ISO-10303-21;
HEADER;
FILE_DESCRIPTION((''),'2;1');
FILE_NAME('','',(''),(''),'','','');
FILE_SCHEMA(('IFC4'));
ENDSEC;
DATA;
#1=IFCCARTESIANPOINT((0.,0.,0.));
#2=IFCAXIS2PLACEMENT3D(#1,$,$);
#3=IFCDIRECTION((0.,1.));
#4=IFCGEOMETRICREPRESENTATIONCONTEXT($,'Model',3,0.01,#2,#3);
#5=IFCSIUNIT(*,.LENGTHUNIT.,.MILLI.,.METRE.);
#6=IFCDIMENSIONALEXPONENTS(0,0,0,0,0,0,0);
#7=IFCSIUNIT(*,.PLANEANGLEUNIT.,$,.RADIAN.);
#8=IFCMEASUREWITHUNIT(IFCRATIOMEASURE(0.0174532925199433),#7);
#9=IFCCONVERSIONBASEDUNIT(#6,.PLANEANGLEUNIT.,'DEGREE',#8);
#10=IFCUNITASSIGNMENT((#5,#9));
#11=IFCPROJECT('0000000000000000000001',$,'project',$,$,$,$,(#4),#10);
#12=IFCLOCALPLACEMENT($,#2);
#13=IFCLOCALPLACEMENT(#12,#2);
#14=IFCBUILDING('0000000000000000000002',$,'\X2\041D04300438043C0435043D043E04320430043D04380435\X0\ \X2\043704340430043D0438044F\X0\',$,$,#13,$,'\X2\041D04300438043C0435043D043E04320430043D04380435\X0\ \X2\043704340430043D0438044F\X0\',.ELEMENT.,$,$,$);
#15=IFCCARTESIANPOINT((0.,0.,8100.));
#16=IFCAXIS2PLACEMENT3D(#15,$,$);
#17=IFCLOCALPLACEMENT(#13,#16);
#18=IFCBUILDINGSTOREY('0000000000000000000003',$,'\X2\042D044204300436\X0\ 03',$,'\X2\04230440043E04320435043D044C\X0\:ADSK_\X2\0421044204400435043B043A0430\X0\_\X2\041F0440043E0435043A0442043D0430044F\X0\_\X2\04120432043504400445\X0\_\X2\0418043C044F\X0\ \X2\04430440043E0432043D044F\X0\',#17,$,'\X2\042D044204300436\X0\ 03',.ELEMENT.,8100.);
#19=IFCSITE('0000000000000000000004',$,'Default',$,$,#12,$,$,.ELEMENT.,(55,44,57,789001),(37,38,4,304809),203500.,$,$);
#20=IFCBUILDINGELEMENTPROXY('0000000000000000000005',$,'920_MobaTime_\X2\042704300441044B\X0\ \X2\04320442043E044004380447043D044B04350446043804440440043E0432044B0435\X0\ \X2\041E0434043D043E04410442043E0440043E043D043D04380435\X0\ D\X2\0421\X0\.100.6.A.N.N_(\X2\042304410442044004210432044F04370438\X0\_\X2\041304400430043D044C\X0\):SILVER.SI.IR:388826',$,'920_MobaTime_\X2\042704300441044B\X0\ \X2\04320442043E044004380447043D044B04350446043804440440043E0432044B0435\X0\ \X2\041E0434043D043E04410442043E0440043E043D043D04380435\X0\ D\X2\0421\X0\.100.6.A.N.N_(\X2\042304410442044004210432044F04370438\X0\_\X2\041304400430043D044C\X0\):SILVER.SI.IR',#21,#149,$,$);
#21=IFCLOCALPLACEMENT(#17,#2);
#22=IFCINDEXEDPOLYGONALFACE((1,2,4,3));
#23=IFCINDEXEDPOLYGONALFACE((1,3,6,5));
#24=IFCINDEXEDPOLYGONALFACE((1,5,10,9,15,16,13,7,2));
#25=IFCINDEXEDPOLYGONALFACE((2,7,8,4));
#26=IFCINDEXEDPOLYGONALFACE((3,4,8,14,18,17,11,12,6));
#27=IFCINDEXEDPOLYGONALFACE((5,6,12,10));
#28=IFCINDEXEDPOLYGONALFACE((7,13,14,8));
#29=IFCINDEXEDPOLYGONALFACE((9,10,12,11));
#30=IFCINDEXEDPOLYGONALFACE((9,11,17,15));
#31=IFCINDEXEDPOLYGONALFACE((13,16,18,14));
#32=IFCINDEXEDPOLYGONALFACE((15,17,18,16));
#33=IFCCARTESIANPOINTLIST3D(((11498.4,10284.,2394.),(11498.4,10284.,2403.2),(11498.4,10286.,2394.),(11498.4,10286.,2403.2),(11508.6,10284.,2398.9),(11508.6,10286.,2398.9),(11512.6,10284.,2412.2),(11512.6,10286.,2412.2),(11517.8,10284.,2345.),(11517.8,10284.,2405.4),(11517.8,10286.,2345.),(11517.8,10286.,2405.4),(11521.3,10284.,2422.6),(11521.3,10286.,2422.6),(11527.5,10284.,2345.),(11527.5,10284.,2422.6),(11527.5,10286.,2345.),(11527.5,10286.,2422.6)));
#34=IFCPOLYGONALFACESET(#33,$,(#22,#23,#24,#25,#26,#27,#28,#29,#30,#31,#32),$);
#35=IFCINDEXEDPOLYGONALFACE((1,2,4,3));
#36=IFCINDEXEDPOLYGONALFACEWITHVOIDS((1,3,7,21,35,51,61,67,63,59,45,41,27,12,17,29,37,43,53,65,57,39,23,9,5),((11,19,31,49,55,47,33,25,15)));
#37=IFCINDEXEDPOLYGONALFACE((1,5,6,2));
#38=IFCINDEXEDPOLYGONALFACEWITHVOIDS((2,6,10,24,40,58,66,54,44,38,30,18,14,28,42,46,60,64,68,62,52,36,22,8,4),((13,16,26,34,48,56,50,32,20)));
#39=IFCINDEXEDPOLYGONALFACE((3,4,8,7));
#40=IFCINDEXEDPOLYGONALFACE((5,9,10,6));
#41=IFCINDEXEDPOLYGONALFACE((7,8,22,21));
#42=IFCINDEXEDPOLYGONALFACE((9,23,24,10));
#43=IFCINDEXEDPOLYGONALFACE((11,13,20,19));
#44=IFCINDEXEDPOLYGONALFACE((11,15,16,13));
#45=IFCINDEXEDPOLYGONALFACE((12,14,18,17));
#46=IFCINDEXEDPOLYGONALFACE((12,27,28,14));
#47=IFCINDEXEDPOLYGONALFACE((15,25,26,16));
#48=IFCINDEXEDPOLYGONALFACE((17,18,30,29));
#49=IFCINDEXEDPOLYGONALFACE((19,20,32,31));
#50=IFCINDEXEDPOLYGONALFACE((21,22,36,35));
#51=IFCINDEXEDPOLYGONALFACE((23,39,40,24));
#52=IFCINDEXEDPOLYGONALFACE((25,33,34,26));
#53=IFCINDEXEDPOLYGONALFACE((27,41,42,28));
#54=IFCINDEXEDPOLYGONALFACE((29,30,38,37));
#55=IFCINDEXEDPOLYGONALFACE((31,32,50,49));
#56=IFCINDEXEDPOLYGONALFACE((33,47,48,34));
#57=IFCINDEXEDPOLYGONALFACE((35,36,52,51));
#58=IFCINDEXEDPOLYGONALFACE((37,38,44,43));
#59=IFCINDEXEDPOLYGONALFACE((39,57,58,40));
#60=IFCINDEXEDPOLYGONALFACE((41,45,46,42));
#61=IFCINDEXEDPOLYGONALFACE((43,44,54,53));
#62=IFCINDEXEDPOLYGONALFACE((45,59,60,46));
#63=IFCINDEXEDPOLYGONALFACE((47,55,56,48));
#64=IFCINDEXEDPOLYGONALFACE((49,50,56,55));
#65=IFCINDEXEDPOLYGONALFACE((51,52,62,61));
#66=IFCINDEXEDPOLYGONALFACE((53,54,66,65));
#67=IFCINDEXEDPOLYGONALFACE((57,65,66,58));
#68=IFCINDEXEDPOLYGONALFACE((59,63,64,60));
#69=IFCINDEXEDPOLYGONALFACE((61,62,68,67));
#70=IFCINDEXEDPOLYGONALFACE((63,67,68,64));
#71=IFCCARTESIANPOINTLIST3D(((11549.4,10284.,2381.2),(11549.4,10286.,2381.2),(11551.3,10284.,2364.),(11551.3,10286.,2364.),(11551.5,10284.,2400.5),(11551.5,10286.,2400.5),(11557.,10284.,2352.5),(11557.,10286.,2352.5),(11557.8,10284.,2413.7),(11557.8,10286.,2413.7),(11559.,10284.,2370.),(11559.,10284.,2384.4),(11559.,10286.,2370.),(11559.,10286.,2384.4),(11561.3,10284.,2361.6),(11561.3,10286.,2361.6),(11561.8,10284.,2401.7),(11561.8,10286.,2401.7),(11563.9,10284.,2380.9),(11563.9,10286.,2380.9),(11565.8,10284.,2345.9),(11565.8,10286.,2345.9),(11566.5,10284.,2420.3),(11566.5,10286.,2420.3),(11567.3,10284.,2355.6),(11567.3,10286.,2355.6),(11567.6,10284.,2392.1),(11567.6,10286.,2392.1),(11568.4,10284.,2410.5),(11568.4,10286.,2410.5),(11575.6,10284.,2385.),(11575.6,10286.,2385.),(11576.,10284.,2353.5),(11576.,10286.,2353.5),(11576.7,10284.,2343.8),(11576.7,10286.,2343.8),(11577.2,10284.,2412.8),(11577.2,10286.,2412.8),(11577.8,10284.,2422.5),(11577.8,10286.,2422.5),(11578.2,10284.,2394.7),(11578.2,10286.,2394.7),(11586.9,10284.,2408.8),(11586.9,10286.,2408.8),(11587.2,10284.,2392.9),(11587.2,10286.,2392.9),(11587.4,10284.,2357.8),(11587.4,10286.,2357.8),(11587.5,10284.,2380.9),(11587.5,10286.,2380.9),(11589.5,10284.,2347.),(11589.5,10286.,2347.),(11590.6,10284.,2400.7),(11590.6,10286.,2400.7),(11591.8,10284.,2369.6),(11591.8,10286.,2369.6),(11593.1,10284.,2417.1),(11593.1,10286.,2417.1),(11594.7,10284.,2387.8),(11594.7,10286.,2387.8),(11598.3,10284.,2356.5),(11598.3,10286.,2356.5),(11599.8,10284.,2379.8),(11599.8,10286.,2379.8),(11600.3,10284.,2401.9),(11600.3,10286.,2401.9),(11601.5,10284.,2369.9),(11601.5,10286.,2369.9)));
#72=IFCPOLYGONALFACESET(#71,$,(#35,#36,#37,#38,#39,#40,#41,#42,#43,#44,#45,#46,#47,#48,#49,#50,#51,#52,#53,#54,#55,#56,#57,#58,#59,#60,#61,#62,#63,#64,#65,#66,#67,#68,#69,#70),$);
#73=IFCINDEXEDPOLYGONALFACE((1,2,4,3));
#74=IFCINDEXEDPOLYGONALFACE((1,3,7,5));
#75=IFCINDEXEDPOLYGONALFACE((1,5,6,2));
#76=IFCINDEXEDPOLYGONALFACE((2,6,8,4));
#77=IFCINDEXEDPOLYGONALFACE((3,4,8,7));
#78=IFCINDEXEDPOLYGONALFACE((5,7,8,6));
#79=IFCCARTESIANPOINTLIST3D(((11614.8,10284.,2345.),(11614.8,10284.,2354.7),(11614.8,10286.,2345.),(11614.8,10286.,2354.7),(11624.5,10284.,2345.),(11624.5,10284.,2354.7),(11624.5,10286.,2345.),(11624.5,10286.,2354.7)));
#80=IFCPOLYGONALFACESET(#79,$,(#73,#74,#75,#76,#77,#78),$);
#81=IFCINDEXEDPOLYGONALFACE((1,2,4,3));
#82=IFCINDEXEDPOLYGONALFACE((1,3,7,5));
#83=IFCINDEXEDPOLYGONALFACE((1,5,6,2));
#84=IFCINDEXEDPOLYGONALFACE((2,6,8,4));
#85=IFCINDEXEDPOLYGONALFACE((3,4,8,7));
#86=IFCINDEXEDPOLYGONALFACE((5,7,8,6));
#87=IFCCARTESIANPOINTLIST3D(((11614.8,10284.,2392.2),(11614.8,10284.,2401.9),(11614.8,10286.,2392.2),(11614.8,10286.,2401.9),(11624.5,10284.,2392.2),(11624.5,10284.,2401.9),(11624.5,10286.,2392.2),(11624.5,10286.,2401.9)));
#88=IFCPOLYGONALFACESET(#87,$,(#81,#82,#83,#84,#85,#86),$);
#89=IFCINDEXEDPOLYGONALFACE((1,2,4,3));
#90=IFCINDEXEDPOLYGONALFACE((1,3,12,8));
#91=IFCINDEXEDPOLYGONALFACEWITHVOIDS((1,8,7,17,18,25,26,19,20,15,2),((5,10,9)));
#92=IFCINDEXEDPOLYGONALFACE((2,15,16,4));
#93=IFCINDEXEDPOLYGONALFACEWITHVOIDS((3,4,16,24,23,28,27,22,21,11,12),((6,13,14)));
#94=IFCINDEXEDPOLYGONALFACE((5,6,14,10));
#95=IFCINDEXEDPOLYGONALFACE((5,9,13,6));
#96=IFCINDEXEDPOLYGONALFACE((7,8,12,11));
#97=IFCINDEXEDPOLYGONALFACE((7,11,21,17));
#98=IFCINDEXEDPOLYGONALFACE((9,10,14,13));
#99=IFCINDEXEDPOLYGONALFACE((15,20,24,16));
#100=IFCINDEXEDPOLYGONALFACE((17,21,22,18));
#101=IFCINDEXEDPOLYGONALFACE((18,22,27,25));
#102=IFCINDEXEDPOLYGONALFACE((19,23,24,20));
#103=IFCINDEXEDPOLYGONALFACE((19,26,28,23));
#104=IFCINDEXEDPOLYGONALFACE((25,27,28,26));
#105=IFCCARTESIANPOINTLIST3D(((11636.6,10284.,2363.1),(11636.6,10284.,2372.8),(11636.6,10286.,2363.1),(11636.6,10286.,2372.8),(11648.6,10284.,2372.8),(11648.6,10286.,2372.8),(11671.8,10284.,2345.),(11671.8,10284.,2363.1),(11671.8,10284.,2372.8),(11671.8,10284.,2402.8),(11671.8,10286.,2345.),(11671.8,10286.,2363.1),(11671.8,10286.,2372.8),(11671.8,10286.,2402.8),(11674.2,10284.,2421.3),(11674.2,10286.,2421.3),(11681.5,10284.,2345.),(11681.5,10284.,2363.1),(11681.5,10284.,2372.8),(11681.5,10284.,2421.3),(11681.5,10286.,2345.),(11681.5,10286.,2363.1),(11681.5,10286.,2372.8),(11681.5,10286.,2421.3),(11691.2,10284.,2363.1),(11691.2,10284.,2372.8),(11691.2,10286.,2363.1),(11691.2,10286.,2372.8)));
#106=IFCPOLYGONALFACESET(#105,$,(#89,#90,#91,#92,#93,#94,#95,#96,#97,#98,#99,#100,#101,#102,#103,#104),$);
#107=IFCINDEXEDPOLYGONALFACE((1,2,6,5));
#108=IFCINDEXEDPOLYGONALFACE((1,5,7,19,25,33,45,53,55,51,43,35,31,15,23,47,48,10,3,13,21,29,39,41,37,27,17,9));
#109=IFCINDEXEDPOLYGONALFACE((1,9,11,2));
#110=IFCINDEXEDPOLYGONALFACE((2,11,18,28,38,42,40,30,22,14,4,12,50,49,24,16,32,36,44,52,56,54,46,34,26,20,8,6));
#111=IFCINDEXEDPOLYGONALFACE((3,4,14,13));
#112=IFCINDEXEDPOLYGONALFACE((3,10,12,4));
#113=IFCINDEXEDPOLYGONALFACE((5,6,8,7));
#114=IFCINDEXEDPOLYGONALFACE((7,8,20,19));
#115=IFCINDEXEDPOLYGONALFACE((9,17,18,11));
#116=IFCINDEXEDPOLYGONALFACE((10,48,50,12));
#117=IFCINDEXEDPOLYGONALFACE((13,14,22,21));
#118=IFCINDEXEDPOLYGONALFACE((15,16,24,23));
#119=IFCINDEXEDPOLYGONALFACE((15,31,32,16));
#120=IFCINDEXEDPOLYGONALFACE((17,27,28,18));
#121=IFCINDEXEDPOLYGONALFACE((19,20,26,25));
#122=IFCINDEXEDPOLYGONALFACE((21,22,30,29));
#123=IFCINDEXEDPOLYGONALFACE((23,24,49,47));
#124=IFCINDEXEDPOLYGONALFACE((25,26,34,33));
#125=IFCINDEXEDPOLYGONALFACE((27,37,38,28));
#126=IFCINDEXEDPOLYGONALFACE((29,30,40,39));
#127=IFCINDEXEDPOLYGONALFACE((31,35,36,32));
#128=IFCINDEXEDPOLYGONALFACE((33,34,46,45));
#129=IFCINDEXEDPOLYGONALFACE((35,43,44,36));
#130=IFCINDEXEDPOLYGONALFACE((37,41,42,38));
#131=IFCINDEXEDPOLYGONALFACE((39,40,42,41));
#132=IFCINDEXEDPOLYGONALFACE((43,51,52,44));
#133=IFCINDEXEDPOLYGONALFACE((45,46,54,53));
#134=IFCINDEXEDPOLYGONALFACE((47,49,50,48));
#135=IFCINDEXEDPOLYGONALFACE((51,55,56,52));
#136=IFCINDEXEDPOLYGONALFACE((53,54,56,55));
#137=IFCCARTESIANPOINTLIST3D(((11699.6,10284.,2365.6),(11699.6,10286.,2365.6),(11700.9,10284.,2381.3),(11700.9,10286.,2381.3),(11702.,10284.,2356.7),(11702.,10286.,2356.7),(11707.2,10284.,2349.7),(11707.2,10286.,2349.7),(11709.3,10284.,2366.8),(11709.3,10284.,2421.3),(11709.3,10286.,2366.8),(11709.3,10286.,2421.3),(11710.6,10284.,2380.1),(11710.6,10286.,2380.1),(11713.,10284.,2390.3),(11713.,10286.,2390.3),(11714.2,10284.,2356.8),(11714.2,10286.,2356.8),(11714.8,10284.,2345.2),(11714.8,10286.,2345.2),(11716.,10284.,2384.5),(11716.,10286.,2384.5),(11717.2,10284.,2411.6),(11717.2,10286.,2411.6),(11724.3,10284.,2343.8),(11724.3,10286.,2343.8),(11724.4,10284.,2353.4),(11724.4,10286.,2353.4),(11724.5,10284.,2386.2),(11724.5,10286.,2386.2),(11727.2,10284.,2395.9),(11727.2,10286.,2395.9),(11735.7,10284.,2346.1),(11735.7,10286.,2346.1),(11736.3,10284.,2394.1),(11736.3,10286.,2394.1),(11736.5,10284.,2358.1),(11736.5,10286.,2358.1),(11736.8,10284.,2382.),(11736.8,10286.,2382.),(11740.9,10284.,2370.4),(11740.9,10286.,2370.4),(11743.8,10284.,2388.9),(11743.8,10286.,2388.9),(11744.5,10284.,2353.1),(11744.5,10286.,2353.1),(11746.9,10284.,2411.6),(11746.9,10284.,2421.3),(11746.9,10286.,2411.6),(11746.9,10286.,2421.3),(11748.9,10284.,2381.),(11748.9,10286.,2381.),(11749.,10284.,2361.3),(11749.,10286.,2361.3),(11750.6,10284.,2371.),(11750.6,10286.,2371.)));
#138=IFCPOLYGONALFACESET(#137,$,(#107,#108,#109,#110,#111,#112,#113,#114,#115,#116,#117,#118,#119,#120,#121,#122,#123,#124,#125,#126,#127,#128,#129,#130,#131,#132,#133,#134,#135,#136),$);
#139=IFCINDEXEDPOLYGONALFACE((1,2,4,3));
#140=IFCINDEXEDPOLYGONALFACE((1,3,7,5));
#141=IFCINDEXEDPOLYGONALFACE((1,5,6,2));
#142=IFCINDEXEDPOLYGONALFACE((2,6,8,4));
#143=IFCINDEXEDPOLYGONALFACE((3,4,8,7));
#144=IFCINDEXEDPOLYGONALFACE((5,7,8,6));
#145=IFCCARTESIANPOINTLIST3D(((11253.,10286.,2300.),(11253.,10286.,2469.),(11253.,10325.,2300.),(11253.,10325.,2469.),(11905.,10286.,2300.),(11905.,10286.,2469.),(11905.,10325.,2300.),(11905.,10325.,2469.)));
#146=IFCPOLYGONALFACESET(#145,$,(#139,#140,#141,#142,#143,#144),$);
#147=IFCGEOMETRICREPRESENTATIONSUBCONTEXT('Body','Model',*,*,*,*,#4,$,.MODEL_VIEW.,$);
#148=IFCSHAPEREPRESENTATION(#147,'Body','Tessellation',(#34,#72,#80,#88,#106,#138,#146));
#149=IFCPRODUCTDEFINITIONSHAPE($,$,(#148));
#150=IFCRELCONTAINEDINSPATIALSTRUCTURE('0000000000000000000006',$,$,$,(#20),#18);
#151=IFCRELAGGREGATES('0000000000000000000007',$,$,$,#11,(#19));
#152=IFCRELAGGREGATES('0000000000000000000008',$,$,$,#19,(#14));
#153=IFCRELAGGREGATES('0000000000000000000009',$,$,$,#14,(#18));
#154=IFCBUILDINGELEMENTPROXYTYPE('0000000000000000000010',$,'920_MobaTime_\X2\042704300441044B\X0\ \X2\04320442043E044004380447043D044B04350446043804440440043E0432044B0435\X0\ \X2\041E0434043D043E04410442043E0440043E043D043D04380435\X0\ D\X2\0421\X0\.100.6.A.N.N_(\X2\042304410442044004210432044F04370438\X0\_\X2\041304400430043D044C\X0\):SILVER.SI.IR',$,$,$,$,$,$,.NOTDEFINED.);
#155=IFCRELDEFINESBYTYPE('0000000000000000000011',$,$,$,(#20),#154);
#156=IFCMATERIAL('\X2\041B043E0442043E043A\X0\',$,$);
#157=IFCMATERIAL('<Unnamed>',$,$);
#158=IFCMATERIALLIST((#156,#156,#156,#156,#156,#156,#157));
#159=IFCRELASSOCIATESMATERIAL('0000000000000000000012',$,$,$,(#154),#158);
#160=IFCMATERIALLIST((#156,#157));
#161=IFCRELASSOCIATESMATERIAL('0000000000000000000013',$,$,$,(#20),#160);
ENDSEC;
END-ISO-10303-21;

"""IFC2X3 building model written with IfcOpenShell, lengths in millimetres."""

from ifc_helpers import new_model, entity, si_unit, converted_unit, direction, frame, origin, origin_2d_with_axis, place, context, subcontext, project, spatial, polyline, rectangle, outline, extrude, source, transform, mapped, material, material_list, type_object, type_shapes, element, save


model = new_model("IFC2X3")

# Units and contexts
model_context = context("Model", 3, precision=0.01, world=origin(), true_north=direction((0.0, 1.0)))
body_context = subcontext(model_context, "Body", "Model", "MODEL_VIEW")
ifc_project = project(units=[si_unit("LENGTHUNIT", "METRE", prefix="MILLI"), converted_unit("PLANEANGLEUNIT", "DEGREE", entity("IfcRatioMeasure", 0.0174532925199433), si_unit("PLANEANGLEUNIT", "RADIAN"), dimensions=[0, 0, 0, 0, 0, 0, 0])], contexts=[model_context])

# Site, building, storey
site_placement = place(None, origin())
site = spatial("IfcSite", under=ifc_project, at=site_placement, Name="Default", CompositionType="ELEMENT", RefLatitude=(55, 44, 57, 789001), RefLongitude=(37, 38, 4, 304809), RefElevation=203500.0)
building_placement = place(site_placement, origin())
building = spatial("IfcBuilding", under=site, at=building_placement, Name="Наименование здания", LongName="Наименование здания", CompositionType="ELEMENT")
storey_placement = place(building_placement, frame((0.0, 0.0, 8100.0)))
storey = spatial("IfcBuildingStorey", under=building, at=storey_placement, Name="Этаж 03", ObjectType="Уровень:ADSK_Стрелка_Проектная_Вверх_Имя уровня", LongName="Этаж 03", CompositionType="ELEMENT", Elevation=8100.0)

# Building element proxy
ifc_material_1 = material(Name="Лоток")
ifc_material_2 = material(Name="<Unnamed>")
ifc_material_list_1 = material_list([ifc_material_1, ifc_material_1, ifc_material_1, ifc_material_1, ifc_material_1, ifc_material_1, ifc_material_2])
building_element_proxy_type = type_object("IfcBuildingElementProxyType", Name="920_MobaTime_Часы вторичныецифровые Односторонние DС.100.6.A.N.N_(УстрСвязи_Грань):SILVER.SI.IR", PredefinedType="NOTDEFINED", material=ifc_material_list_1)
shared_shape = source(origin(), body_context, "Body", "SweptSolid", [
    extrude(outline(polyline([(-49.3, -13.1), (28.2, -13.1), (28.2, -6.8), (17.9, 1.8), (8.8, 16.0), (-0.3, 16.0), (4.6, 5.8), (11.1, -3.4), (-49.3, -3.4), (-49.3, -13.1)])), frame((-64.6, 9.8, 39.0), z_axis=(0.0, 0.0, 1.0), x_axis=(0.0, 1.0, 0.0)), (0.0, 0.0, 1.0), 2.0),
    extrude(outline(polyline([(2.2, -27.6), (19.0, -27.6), (30.5, -16.1), (33.3, -4.9), (31.0, 5.8), (21.8, 17.2), (5.2, 27.3), (-11.1, 33.0), (-24.0, 32.7), (-33.6, 27.6), (-40.3, 18.6), (-42.8, 5.7), (-38.0, -6.3), (-27.2, -14.9), (-17.5, -17.7), (-8.2, -16.4), (-0.3, -11.9), (5.1, -4.5), (7.3, 6.2), (4.0, 17.2), (18.4, 7.3), (23.6, -2.4), (22.0, -11.4), (14.2, -18.4), (5.3, -18.3), (2.2, -27.6)]), holes=[polyline([(-9.0, 23.3), (-1.3, 14.3), (-2.5, 2.0), (-11.4, -7.0), (-23.4, -6.0), (-32.2, 2.9), (-31.2, 15.1), (-25.6, 22.1), (-17.5, 24.9), (-9.0, 23.3)])]), frame((-2.7, 3.6, 39.0), z_axis=(0.0, 0.0, 1.0), x_axis=(-0.427649, 0.903945, 0.0)), (0.0, 0.0, 1.0), 2.0),
    extrude(rectangle(XDim=9.7, YDim=9.7, at=origin_2d_with_axis()), frame((40.6, -34.7, 39.0)), (0.0, 0.0, 1.0), 2.0),
    extrude(rectangle(XDim=9.7, YDim=9.7, at=origin_2d_with_axis()), frame((40.6, 12.6, 39.0)), (0.0, 0.0, 1.0), 2.0),
    extrude(outline(polyline([(-0.9, -28.1), (8.8, -28.1), (8.8, -9.9), (18.5, -9.9), (18.5, -0.2), (8.8, -0.2), (8.8, 48.3), (1.5, 48.3), (-36.0, -0.2), (-36.0, -9.9), (-0.9, -9.9), (-0.9, -28.1)]), holes=[polyline([(-0.9, -0.2), (-24.1, -0.2), (-0.9, 29.7), (-0.9, -0.2)])]), frame((93.6, -11.4, 39.0)), (0.0, 0.0, 1.0), 2.0),
    extrude(outline(polyline([(3.3, -28.3), (12.5, -28.3), (20.5, -25.0), (26.8, -18.9), (30.7, -10.0), (31.4, 1.6), (26.9, 11.8), (20.1, 18.4), (11.1, 22.3), (1.0, 23.3), (-7.9, 20.4), (-14.9, 14.5), (-18.9, 6.2), (-17.1, -9.0), (-36.7, 0.5), (-29.1, 29.2), (-38.5, 31.7), (-48.1, -4.6), (-11.6, -23.1), (-8.0, -14.0), (-10.8, -7.6), (-10.2, 1.1), (-3.0, 11.8), (9.2, 12.8), (20.0, 5.5), (21.4, -7.5), (15.5, -16.4), (4.6, -18.6), (3.3, -28.3)])), frame((147.1, -8.5, 39.0), z_axis=(0.0, 0.0, 1.0), x_axis=(0.256974, -0.966418, 0.0)), (0.0, 0.0, 1.0), 2.0),
    extrude(rectangle(XDim=652.0, YDim=169.0, at=origin_2d_with_axis()), frame((0.0, 0.0, 0.0), z_axis=(0.0, 0.0, 1.0), x_axis=(-1.0, 0.0, 0.0)), (0.0, 0.0, 1.0), 39.0),
])
type_shapes(building_element_proxy_type, [shared_shape])
ifc_material_list_2 = material_list([ifc_material_1, ifc_material_2])
for number, where, z_axis, x_axis, name in (
    (1, (11579.0, 10325.0, 2384.5), (0.0, -1.0, 0.0), (1.0, 0.0, 0.0), "920_MobaTime_Часы вторичныецифровые Односторонние DС.100.6.A.N.N_(УстрСвязи_Грань):SILVER.SI.IR:388826"),
):
    element("IfcBuildingElementProxy", number, at=place(storey_placement, frame(where, z_axis=z_axis, x_axis=x_axis)), inside=storey, type_object=building_element_proxy_type, material=ifc_material_list_2, Name=name, ObjectType="920_MobaTime_Часы вторичныецифровые Односторонние DС.100.6.A.N.N_(УстрСвязи_Грань):SILVER.SI.IR", context=body_context, shape_type="MappedRepresentation", body=[
        mapped(shared_shape, transform((0.0, 0.0, 0.0), scale=1.0)),
    ])

save(model, "model.ifc")
